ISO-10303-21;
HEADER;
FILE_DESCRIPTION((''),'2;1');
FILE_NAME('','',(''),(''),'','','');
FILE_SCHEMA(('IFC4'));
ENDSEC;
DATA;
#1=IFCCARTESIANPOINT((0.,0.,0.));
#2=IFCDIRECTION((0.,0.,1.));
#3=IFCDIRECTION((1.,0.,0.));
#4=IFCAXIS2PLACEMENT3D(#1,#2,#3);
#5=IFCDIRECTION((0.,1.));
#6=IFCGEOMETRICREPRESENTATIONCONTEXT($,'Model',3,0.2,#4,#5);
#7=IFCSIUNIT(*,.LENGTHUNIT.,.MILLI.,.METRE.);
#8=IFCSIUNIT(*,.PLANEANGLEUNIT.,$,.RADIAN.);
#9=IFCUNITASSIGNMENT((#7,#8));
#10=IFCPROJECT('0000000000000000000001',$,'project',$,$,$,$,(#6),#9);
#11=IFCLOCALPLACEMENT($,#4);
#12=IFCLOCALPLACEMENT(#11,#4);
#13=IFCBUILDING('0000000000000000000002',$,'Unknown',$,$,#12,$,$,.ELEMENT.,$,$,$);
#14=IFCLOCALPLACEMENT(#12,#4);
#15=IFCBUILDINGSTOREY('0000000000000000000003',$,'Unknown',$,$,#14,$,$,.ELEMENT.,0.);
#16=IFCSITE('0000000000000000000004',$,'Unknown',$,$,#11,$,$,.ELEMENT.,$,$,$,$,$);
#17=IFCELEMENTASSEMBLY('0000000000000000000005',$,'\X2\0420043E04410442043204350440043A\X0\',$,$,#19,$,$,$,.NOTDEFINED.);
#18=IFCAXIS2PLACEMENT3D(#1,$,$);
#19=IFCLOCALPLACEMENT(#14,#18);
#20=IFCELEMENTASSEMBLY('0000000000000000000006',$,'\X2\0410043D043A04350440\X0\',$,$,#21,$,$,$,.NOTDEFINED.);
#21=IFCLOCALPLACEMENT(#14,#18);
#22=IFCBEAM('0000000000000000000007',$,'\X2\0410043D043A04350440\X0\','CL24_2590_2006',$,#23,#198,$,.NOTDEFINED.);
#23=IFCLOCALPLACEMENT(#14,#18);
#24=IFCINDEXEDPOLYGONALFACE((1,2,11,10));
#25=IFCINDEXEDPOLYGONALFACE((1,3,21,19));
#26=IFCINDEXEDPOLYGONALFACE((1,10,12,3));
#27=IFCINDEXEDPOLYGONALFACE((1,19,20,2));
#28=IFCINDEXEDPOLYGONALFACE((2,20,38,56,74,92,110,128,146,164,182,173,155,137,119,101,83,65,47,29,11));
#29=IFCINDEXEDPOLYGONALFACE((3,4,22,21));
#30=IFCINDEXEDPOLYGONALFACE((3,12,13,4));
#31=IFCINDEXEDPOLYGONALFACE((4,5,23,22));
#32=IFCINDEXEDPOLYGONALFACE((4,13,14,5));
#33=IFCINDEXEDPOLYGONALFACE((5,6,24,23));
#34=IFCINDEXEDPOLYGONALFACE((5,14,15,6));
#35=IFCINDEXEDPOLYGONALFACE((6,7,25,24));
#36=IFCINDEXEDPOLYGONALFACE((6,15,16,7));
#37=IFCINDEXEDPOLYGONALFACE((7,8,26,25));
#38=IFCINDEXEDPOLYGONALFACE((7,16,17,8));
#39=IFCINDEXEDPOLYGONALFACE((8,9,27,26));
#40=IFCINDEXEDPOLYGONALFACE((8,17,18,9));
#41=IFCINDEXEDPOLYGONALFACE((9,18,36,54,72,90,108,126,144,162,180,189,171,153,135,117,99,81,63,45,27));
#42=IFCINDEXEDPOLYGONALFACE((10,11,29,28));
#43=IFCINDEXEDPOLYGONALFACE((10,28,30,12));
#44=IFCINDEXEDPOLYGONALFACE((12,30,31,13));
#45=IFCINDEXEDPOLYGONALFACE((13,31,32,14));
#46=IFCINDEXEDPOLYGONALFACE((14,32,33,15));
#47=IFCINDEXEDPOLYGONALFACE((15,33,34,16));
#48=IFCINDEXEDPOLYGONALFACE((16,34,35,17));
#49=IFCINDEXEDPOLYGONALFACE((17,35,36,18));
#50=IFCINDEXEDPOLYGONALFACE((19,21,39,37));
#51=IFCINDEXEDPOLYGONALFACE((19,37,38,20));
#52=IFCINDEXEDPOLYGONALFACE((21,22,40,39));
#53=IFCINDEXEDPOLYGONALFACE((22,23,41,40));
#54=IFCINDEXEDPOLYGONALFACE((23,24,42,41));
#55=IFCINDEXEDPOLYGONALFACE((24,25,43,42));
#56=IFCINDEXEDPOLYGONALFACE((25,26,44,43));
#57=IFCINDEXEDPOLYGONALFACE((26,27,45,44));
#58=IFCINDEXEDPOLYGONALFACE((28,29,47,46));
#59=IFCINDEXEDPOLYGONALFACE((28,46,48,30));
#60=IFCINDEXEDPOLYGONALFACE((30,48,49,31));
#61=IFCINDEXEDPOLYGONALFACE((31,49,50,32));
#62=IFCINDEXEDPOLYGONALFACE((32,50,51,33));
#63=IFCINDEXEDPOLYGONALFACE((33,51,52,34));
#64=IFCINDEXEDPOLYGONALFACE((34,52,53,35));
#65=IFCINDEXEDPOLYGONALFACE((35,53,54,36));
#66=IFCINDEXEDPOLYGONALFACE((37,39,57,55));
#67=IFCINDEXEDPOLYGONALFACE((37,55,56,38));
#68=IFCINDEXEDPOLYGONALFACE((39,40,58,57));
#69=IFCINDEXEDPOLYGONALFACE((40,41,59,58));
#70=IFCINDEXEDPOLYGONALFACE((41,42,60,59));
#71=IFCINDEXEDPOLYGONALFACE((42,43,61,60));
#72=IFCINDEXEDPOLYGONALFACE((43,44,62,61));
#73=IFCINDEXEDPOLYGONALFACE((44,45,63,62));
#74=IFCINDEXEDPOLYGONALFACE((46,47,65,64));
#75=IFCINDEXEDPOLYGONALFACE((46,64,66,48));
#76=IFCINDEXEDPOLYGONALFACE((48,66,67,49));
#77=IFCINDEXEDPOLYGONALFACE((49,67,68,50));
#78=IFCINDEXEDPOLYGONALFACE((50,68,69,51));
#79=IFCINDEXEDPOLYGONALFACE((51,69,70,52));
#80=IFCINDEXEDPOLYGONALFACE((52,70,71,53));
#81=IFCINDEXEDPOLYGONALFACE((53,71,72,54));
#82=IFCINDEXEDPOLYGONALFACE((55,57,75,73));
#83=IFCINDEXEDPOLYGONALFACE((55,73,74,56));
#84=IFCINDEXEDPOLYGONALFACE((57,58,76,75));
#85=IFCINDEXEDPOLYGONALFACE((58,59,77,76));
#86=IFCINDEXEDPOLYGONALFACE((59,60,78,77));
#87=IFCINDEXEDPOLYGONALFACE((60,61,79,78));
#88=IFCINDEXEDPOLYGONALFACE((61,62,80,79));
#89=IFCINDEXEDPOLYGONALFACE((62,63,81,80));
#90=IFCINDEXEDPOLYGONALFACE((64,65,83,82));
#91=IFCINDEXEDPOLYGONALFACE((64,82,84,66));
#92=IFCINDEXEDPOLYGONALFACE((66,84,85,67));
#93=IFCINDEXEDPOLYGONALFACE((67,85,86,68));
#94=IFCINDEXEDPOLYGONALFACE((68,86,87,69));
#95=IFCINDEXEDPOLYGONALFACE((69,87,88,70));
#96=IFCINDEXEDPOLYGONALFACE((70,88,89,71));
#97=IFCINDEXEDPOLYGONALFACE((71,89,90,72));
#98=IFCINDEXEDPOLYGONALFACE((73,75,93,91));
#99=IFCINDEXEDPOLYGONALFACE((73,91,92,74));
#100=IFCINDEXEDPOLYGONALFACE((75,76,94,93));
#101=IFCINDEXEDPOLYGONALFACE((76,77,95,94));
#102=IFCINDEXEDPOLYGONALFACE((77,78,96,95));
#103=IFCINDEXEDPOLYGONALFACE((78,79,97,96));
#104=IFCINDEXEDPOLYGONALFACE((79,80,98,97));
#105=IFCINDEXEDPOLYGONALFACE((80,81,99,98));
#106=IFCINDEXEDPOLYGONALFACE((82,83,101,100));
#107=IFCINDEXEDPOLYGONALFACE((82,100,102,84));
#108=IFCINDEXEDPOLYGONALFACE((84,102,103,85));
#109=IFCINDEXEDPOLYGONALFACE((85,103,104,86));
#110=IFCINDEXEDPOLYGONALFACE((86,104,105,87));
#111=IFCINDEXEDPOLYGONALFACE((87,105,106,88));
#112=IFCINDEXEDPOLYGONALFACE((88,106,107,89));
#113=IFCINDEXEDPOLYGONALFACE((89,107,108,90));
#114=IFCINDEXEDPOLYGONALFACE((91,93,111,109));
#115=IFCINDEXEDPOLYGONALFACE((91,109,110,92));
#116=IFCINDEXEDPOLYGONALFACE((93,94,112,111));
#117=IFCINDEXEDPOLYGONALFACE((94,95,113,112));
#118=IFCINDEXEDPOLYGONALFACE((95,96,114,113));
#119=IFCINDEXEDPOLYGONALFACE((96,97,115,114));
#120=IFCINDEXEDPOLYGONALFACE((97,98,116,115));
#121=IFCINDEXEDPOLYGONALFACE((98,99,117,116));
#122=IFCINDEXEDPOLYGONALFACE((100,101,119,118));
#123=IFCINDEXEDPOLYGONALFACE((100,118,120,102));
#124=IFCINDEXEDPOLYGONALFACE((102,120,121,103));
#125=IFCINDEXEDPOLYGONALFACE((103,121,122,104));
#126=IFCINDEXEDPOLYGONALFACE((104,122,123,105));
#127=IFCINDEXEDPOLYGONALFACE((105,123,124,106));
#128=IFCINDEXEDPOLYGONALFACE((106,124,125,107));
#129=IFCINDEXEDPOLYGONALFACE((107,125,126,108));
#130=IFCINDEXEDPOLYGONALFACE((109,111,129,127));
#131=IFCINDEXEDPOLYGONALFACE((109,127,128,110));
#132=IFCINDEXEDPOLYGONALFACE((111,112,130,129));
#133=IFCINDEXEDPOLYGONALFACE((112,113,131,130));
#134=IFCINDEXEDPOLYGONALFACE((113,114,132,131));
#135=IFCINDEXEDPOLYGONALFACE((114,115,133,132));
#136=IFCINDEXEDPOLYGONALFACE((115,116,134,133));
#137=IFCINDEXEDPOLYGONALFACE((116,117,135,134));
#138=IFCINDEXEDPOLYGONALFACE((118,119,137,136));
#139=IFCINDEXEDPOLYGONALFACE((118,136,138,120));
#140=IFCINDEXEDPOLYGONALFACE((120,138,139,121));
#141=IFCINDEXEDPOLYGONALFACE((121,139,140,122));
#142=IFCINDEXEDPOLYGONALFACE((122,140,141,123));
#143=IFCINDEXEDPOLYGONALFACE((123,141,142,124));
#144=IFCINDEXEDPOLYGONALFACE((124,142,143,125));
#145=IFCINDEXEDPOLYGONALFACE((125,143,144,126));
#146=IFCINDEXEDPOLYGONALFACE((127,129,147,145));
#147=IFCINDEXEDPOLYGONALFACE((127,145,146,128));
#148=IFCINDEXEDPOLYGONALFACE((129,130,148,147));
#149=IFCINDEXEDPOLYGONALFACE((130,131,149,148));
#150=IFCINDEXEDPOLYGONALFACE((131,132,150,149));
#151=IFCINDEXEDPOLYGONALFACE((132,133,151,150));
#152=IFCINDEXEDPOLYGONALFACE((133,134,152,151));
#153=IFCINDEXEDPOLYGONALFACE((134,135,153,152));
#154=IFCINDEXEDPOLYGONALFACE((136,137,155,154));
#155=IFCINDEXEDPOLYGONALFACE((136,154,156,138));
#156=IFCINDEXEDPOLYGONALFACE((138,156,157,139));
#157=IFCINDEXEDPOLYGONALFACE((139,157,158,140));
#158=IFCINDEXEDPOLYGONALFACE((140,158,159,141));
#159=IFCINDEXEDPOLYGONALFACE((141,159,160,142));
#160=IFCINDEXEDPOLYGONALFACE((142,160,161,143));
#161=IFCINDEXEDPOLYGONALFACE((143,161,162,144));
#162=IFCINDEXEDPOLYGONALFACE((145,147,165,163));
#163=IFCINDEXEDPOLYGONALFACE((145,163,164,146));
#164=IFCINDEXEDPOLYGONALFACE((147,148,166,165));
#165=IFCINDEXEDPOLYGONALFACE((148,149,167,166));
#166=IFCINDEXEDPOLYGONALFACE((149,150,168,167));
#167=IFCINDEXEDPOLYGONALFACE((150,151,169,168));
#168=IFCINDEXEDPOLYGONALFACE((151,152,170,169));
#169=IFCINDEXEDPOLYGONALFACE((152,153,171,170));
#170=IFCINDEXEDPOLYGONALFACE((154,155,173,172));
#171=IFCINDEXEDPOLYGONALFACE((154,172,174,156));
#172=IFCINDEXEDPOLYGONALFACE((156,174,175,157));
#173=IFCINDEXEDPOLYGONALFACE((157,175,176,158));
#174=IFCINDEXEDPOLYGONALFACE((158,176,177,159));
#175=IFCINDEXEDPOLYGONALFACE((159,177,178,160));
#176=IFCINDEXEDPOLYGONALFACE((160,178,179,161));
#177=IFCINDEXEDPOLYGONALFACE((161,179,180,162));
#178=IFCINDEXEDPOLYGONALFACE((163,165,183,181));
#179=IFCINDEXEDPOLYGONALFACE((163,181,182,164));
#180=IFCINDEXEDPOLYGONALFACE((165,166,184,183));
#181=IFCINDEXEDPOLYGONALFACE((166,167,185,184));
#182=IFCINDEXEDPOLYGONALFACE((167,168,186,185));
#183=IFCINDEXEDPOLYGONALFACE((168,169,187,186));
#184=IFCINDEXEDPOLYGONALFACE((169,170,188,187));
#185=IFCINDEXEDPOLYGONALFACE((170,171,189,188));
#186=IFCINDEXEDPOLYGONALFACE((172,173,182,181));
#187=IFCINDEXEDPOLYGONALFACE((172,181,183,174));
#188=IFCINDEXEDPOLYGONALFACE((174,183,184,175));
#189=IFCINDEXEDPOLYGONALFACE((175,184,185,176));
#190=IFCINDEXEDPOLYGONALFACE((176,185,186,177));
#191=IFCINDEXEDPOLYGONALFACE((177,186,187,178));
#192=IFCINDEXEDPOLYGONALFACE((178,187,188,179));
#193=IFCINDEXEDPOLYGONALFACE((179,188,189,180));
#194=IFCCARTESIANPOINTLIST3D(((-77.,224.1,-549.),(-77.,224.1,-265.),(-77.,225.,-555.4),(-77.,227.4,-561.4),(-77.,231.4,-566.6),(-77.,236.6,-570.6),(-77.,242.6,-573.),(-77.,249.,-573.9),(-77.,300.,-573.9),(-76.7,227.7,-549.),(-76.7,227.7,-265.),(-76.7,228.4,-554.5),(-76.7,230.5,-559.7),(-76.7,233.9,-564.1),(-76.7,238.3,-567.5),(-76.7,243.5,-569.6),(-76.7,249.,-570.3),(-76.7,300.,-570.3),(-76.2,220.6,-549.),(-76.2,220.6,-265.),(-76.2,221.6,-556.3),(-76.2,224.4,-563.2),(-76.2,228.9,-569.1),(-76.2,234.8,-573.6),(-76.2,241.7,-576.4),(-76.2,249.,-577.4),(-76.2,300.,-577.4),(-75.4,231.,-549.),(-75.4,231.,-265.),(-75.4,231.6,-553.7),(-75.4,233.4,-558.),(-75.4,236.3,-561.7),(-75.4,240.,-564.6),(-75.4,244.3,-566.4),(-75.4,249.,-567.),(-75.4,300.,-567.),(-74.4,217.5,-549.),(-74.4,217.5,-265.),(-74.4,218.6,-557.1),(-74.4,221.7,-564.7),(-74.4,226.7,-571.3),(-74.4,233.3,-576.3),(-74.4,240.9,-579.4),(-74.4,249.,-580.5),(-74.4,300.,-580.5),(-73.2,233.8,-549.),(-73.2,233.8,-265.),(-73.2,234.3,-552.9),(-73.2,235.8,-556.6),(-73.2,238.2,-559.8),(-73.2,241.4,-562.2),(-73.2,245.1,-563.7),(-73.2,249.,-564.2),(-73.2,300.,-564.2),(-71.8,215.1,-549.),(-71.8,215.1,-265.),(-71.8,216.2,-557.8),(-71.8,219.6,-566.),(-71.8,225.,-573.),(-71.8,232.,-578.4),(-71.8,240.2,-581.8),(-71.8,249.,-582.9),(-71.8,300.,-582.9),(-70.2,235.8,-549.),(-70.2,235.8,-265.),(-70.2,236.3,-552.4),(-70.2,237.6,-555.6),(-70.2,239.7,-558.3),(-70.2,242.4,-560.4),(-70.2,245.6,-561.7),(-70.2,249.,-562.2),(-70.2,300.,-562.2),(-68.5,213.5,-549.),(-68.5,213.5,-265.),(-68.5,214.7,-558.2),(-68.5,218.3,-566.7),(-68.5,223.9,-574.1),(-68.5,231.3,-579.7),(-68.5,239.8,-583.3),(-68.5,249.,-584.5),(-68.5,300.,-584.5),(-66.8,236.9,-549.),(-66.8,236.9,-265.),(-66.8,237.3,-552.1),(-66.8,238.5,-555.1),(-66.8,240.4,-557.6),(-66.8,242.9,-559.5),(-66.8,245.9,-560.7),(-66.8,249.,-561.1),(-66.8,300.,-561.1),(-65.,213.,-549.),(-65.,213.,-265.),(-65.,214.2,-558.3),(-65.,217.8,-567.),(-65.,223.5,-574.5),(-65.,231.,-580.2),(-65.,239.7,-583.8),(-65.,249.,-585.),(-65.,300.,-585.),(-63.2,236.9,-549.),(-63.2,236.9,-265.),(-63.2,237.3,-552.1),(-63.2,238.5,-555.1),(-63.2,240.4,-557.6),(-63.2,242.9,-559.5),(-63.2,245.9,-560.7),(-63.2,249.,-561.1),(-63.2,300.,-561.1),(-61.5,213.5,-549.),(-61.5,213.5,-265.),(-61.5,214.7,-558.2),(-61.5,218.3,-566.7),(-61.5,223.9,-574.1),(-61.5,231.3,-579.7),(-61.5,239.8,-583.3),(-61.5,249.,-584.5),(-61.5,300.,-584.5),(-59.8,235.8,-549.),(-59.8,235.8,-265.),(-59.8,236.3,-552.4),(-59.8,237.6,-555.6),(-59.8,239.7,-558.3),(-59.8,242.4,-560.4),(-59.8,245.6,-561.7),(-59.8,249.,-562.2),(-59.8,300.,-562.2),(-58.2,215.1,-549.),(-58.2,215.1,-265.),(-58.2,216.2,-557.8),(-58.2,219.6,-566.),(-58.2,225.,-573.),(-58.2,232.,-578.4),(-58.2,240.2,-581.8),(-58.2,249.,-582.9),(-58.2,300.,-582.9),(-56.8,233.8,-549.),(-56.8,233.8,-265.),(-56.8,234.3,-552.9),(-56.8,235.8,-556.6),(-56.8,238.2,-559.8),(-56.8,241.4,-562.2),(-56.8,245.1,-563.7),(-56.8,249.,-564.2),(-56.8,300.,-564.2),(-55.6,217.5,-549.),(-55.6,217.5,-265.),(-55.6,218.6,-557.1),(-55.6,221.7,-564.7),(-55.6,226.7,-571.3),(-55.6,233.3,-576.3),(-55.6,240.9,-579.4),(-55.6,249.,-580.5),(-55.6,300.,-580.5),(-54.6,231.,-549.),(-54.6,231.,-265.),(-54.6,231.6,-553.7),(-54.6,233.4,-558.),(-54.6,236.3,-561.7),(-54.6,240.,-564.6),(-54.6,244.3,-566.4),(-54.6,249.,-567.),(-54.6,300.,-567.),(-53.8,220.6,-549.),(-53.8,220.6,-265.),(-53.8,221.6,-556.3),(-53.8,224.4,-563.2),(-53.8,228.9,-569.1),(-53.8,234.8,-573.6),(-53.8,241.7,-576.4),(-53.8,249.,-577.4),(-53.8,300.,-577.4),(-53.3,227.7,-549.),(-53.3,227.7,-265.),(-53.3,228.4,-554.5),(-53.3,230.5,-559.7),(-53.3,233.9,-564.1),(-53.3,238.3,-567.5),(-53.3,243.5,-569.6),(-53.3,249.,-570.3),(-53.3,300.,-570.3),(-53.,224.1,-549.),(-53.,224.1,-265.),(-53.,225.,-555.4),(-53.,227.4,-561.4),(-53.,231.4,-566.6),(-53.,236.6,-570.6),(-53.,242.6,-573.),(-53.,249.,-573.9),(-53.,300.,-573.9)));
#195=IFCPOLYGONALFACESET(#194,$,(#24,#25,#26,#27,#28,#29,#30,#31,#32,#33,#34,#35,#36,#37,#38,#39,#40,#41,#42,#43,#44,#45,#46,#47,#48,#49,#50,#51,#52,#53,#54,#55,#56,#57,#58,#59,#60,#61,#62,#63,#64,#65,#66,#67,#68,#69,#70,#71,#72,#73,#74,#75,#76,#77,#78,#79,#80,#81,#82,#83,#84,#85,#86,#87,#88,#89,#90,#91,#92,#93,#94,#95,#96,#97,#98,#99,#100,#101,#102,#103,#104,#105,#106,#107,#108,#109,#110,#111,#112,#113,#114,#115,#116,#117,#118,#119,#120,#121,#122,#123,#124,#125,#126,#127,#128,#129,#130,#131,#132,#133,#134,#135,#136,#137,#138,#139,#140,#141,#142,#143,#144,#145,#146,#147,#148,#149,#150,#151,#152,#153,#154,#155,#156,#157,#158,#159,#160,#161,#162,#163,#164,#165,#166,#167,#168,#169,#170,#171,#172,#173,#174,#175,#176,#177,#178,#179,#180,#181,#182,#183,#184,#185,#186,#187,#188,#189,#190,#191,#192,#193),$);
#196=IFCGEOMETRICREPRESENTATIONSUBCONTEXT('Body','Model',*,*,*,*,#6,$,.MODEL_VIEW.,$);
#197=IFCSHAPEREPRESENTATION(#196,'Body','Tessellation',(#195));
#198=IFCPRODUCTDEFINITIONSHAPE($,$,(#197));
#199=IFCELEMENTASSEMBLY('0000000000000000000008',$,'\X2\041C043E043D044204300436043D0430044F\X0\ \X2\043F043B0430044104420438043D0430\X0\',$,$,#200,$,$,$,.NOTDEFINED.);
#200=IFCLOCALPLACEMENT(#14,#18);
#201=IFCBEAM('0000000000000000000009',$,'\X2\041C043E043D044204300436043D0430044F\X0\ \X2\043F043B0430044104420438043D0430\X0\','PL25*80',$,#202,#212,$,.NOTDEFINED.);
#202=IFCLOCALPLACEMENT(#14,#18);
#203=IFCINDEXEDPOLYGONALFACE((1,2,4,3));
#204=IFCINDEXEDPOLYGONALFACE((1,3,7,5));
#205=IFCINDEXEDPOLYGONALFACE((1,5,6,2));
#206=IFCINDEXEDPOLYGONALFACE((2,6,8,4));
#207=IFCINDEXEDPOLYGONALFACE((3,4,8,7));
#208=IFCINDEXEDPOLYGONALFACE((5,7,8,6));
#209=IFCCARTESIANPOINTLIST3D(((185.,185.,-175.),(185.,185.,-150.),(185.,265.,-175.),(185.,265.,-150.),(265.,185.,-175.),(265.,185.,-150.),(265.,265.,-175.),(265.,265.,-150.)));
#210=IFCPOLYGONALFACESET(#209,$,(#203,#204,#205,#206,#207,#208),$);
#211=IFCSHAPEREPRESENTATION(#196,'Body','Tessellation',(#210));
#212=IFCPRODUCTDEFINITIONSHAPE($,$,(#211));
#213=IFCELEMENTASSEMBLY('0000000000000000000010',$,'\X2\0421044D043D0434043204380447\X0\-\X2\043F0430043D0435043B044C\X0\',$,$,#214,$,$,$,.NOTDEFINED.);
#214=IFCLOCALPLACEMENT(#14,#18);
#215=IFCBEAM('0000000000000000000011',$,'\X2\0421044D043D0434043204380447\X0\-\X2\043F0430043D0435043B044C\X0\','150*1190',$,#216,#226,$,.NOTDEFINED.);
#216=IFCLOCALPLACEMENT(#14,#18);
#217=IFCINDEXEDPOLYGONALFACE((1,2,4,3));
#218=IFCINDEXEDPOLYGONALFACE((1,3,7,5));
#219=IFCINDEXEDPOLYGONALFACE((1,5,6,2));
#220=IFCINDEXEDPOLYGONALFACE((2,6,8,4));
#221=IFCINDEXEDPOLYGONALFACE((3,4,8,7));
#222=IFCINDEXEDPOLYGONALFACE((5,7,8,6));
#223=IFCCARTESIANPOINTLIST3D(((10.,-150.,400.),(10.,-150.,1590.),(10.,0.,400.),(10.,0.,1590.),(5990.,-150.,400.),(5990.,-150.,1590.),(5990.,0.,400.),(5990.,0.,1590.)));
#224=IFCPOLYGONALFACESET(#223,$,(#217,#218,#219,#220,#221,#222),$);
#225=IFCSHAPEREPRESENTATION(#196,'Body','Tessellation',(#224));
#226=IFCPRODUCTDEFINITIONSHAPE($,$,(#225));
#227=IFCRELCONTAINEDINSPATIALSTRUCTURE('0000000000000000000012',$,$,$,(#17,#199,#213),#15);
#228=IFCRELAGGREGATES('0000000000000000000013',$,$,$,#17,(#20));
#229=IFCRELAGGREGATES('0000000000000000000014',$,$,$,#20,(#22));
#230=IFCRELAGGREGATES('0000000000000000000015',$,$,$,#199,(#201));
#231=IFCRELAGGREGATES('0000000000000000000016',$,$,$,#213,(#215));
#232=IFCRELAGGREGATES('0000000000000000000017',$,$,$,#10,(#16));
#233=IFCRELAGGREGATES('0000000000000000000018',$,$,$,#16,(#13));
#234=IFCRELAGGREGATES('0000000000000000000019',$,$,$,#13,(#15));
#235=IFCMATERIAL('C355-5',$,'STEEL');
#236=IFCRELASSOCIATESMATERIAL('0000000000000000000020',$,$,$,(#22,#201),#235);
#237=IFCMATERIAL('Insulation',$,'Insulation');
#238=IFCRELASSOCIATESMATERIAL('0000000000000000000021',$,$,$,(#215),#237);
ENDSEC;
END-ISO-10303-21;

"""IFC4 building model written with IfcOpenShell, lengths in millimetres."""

from ifc_helpers import new_model, entity, si_unit, direction, frame, origin_with_axes, place, context, subcontext, project, spatial, line, indexed_curve, outline, extrude, material, element, aggregate, save


model = new_model("IFC4")

# Units and contexts
model_context = context("Model", 3, precision=0.2, world=origin_with_axes(), true_north=direction((0.0, 1.0)))
body_context = subcontext(model_context, "Body", "Model", "MODEL_VIEW")
ifc_project = project(units=[si_unit("LENGTHUNIT", "METRE", prefix="MILLI"), si_unit("PLANEANGLEUNIT", "RADIAN")], contexts=[model_context])

# Site, building, storey
site_placement = place(None, origin_with_axes())
site = spatial("IfcSite", under=ifc_project, at=site_placement, Name="Unknown", CompositionType="ELEMENT")
building_placement = place(site_placement, origin_with_axes())
building = spatial("IfcBuilding", under=site, at=building_placement, Name="Unknown", CompositionType="ELEMENT")
storey_placement = place(building_placement, origin_with_axes())
storey = spatial("IfcBuildingStorey", under=building, at=storey_placement, Name="Unknown", CompositionType="ELEMENT", Elevation=0.0)

# Element assemblies, beam, voiding feature
assembly_1_placement = place(storey_placement, frame((80.0, 80.0, -300.0), z_axis=(0.0, -1.0, 0.0), x_axis=(0.0, 0.0, -1.0)))
assembly_1 = element("IfcElementAssembly", 1, at=assembly_1_placement, inside=storey, Name="Ростверк", PredefinedType="NOTDEFINED")
ifc_material_1 = material(Name="C355-5", Category="STEEL")
assembly_2_placement = place(assembly_1_placement, frame((-215.0, -145.0, -145.0), z_axis=(0.0, 0.0, 1.0), x_axis=(1.0, 0.0, 0.0)))
assembly_2 = element("IfcElementAssembly", 2, at=assembly_2_placement, Name="Анкер", PredefinedType="NOTDEFINED")
aggregate(assembly_1, [assembly_2])
beam_1_placement = place(assembly_2_placement, origin_with_axes())
beam_1 = element("IfcBeam", 3, at=beam_1_placement, material=ifc_material_1, Name="Анкер", Description="CL24_2590_2006", PredefinedType="NOTDEFINED", context=body_context, shape_type="SolidModel", body=[
    entity("IfcSweptDiskSolid", entity("IfcIndexedPolyCurve", entity("IfcCartesianPointList3D", [[0.0, 0.0, 0.0], [464.0, 0.0, 0.0], [481.0, 0.0, -7.0], [488.0, 0.0, -24.0], [488.0, 0.0, -75.0]]), [entity("IfcLineIndex", [1, 2]), entity("IfcArcIndex", [2, 3, 4]), entity("IfcLineIndex", [4, 5])]), 12.0),
])
voiding_feature_1_placement = place(beam_1_placement, frame((0.0, 0.0, 0.0), z_axis=(0.0, -1.0, 0.0), x_axis=(1.0, 0.0, 0.0)))
element("IfcVoidingFeature", 4, at=voiding_feature_1_placement, cuts=beam_1, Name="Анкер", PredefinedType="HOLE", context=body_context, shape_type="SolidModel", body=[
    extrude(outline(indexed_curve([(12.5, 0.0), (12.2, 2.8), (11.3, 5.4), (9.8, 7.8), (7.8, 9.8), (5.4, 11.3), (2.8, 12.2), (0.0, 12.5), (-2.8, 12.2), (-5.4, 11.3), (-7.8, 9.8), (-9.8, 7.8), (-11.3, 5.4), (-12.2, 2.8), (-12.5, 0.0), (-12.2, -2.8), (-11.3, -5.4), (-9.8, -7.8), (-7.8, -9.8), (-5.4, -11.3), (-2.8, -12.2), (0.0, -12.5), (2.8, -12.2), (5.4, -11.3), (7.8, -9.8), (9.8, -7.8), (11.3, -5.4), (12.2, -2.8)], segments=[line(1, 2, 3, 4, 5, 6, 7, 8, 9, 10, 11, 12, 13, 14, 15, 16, 17, 18, 19, 20, 21, 22, 23, 24, 25, 26, 27, 28, 1)])), frame((0.0, 0.0, 0.0), z_axis=(-1.0, 0.0, 0.0), x_axis=(0.0, 0.0, 1.0)), (0.0, 0.0, -1.0), 180.0),
])
aggregate(assembly_2, [beam_1])

# Element assemblies, beams
assembly_3_placement = place(storey_placement, frame((185.0, 225.0, -162.5), z_axis=(0.0, 0.0, -1.0), x_axis=(1.0, 0.0, 0.0)))
assembly_3 = element("IfcElementAssembly", 5, at=assembly_3_placement, inside=storey, Name="Монтажная пластина", PredefinedType="NOTDEFINED")
beam_2_placement = place(assembly_3_placement, origin_with_axes())
beam_2 = element("IfcBeam", 6, at=beam_2_placement, material=ifc_material_1, Name="Монтажная пластина", Description="PL25*80", PredefinedType="NOTDEFINED", context=body_context, shape_type="SolidModel", body=[
    extrude(outline(indexed_curve([(-12.5, -40.0), (12.5, -40.0), (12.5, 40.0), (-12.5, 40.0)], segments=[line(1, 2, 3, 4, 1)])), frame((0.0, 0.0, 0.0), z_axis=(-1.0, 0.0, 0.0), x_axis=(0.0, 0.0, 1.0)), (0.0, 0.0, -1.0), 80.0),
])
aggregate(assembly_3, [beam_2])
assembly_4_placement = place(storey_placement, frame((10.0, -75.0, 995.0), z_axis=(0.0, 0.0, -1.0), x_axis=(1.0, 0.0, 0.0)))
assembly_4 = element("IfcElementAssembly", 7, at=assembly_4_placement, inside=storey, Name="Сэндвич-панель", PredefinedType="NOTDEFINED")
ifc_material_2 = material(Name="Insulation", Category="Insulation")
beam_3_placement = place(assembly_4_placement, origin_with_axes())
beam_3 = element("IfcBeam", 8, at=beam_3_placement, material=ifc_material_2, Name="Сэндвич-панель", Description="150*1190", PredefinedType="NOTDEFINED", context=body_context, shape_type="SolidModel", body=[
    extrude(outline(indexed_curve([(-595.0, -75.0), (595.0, -75.0), (595.0, 75.0), (-595.0, 75.0)], segments=[line(1, 2, 3, 4, 1)])), frame((0.0, 0.0, 0.0), z_axis=(-1.0, 0.0, 0.0), x_axis=(0.0, 0.0, 1.0)), (0.0, 0.0, -1.0), 5980.0),
])
aggregate(assembly_4, [beam_3])

save(model, "model.ifc")
